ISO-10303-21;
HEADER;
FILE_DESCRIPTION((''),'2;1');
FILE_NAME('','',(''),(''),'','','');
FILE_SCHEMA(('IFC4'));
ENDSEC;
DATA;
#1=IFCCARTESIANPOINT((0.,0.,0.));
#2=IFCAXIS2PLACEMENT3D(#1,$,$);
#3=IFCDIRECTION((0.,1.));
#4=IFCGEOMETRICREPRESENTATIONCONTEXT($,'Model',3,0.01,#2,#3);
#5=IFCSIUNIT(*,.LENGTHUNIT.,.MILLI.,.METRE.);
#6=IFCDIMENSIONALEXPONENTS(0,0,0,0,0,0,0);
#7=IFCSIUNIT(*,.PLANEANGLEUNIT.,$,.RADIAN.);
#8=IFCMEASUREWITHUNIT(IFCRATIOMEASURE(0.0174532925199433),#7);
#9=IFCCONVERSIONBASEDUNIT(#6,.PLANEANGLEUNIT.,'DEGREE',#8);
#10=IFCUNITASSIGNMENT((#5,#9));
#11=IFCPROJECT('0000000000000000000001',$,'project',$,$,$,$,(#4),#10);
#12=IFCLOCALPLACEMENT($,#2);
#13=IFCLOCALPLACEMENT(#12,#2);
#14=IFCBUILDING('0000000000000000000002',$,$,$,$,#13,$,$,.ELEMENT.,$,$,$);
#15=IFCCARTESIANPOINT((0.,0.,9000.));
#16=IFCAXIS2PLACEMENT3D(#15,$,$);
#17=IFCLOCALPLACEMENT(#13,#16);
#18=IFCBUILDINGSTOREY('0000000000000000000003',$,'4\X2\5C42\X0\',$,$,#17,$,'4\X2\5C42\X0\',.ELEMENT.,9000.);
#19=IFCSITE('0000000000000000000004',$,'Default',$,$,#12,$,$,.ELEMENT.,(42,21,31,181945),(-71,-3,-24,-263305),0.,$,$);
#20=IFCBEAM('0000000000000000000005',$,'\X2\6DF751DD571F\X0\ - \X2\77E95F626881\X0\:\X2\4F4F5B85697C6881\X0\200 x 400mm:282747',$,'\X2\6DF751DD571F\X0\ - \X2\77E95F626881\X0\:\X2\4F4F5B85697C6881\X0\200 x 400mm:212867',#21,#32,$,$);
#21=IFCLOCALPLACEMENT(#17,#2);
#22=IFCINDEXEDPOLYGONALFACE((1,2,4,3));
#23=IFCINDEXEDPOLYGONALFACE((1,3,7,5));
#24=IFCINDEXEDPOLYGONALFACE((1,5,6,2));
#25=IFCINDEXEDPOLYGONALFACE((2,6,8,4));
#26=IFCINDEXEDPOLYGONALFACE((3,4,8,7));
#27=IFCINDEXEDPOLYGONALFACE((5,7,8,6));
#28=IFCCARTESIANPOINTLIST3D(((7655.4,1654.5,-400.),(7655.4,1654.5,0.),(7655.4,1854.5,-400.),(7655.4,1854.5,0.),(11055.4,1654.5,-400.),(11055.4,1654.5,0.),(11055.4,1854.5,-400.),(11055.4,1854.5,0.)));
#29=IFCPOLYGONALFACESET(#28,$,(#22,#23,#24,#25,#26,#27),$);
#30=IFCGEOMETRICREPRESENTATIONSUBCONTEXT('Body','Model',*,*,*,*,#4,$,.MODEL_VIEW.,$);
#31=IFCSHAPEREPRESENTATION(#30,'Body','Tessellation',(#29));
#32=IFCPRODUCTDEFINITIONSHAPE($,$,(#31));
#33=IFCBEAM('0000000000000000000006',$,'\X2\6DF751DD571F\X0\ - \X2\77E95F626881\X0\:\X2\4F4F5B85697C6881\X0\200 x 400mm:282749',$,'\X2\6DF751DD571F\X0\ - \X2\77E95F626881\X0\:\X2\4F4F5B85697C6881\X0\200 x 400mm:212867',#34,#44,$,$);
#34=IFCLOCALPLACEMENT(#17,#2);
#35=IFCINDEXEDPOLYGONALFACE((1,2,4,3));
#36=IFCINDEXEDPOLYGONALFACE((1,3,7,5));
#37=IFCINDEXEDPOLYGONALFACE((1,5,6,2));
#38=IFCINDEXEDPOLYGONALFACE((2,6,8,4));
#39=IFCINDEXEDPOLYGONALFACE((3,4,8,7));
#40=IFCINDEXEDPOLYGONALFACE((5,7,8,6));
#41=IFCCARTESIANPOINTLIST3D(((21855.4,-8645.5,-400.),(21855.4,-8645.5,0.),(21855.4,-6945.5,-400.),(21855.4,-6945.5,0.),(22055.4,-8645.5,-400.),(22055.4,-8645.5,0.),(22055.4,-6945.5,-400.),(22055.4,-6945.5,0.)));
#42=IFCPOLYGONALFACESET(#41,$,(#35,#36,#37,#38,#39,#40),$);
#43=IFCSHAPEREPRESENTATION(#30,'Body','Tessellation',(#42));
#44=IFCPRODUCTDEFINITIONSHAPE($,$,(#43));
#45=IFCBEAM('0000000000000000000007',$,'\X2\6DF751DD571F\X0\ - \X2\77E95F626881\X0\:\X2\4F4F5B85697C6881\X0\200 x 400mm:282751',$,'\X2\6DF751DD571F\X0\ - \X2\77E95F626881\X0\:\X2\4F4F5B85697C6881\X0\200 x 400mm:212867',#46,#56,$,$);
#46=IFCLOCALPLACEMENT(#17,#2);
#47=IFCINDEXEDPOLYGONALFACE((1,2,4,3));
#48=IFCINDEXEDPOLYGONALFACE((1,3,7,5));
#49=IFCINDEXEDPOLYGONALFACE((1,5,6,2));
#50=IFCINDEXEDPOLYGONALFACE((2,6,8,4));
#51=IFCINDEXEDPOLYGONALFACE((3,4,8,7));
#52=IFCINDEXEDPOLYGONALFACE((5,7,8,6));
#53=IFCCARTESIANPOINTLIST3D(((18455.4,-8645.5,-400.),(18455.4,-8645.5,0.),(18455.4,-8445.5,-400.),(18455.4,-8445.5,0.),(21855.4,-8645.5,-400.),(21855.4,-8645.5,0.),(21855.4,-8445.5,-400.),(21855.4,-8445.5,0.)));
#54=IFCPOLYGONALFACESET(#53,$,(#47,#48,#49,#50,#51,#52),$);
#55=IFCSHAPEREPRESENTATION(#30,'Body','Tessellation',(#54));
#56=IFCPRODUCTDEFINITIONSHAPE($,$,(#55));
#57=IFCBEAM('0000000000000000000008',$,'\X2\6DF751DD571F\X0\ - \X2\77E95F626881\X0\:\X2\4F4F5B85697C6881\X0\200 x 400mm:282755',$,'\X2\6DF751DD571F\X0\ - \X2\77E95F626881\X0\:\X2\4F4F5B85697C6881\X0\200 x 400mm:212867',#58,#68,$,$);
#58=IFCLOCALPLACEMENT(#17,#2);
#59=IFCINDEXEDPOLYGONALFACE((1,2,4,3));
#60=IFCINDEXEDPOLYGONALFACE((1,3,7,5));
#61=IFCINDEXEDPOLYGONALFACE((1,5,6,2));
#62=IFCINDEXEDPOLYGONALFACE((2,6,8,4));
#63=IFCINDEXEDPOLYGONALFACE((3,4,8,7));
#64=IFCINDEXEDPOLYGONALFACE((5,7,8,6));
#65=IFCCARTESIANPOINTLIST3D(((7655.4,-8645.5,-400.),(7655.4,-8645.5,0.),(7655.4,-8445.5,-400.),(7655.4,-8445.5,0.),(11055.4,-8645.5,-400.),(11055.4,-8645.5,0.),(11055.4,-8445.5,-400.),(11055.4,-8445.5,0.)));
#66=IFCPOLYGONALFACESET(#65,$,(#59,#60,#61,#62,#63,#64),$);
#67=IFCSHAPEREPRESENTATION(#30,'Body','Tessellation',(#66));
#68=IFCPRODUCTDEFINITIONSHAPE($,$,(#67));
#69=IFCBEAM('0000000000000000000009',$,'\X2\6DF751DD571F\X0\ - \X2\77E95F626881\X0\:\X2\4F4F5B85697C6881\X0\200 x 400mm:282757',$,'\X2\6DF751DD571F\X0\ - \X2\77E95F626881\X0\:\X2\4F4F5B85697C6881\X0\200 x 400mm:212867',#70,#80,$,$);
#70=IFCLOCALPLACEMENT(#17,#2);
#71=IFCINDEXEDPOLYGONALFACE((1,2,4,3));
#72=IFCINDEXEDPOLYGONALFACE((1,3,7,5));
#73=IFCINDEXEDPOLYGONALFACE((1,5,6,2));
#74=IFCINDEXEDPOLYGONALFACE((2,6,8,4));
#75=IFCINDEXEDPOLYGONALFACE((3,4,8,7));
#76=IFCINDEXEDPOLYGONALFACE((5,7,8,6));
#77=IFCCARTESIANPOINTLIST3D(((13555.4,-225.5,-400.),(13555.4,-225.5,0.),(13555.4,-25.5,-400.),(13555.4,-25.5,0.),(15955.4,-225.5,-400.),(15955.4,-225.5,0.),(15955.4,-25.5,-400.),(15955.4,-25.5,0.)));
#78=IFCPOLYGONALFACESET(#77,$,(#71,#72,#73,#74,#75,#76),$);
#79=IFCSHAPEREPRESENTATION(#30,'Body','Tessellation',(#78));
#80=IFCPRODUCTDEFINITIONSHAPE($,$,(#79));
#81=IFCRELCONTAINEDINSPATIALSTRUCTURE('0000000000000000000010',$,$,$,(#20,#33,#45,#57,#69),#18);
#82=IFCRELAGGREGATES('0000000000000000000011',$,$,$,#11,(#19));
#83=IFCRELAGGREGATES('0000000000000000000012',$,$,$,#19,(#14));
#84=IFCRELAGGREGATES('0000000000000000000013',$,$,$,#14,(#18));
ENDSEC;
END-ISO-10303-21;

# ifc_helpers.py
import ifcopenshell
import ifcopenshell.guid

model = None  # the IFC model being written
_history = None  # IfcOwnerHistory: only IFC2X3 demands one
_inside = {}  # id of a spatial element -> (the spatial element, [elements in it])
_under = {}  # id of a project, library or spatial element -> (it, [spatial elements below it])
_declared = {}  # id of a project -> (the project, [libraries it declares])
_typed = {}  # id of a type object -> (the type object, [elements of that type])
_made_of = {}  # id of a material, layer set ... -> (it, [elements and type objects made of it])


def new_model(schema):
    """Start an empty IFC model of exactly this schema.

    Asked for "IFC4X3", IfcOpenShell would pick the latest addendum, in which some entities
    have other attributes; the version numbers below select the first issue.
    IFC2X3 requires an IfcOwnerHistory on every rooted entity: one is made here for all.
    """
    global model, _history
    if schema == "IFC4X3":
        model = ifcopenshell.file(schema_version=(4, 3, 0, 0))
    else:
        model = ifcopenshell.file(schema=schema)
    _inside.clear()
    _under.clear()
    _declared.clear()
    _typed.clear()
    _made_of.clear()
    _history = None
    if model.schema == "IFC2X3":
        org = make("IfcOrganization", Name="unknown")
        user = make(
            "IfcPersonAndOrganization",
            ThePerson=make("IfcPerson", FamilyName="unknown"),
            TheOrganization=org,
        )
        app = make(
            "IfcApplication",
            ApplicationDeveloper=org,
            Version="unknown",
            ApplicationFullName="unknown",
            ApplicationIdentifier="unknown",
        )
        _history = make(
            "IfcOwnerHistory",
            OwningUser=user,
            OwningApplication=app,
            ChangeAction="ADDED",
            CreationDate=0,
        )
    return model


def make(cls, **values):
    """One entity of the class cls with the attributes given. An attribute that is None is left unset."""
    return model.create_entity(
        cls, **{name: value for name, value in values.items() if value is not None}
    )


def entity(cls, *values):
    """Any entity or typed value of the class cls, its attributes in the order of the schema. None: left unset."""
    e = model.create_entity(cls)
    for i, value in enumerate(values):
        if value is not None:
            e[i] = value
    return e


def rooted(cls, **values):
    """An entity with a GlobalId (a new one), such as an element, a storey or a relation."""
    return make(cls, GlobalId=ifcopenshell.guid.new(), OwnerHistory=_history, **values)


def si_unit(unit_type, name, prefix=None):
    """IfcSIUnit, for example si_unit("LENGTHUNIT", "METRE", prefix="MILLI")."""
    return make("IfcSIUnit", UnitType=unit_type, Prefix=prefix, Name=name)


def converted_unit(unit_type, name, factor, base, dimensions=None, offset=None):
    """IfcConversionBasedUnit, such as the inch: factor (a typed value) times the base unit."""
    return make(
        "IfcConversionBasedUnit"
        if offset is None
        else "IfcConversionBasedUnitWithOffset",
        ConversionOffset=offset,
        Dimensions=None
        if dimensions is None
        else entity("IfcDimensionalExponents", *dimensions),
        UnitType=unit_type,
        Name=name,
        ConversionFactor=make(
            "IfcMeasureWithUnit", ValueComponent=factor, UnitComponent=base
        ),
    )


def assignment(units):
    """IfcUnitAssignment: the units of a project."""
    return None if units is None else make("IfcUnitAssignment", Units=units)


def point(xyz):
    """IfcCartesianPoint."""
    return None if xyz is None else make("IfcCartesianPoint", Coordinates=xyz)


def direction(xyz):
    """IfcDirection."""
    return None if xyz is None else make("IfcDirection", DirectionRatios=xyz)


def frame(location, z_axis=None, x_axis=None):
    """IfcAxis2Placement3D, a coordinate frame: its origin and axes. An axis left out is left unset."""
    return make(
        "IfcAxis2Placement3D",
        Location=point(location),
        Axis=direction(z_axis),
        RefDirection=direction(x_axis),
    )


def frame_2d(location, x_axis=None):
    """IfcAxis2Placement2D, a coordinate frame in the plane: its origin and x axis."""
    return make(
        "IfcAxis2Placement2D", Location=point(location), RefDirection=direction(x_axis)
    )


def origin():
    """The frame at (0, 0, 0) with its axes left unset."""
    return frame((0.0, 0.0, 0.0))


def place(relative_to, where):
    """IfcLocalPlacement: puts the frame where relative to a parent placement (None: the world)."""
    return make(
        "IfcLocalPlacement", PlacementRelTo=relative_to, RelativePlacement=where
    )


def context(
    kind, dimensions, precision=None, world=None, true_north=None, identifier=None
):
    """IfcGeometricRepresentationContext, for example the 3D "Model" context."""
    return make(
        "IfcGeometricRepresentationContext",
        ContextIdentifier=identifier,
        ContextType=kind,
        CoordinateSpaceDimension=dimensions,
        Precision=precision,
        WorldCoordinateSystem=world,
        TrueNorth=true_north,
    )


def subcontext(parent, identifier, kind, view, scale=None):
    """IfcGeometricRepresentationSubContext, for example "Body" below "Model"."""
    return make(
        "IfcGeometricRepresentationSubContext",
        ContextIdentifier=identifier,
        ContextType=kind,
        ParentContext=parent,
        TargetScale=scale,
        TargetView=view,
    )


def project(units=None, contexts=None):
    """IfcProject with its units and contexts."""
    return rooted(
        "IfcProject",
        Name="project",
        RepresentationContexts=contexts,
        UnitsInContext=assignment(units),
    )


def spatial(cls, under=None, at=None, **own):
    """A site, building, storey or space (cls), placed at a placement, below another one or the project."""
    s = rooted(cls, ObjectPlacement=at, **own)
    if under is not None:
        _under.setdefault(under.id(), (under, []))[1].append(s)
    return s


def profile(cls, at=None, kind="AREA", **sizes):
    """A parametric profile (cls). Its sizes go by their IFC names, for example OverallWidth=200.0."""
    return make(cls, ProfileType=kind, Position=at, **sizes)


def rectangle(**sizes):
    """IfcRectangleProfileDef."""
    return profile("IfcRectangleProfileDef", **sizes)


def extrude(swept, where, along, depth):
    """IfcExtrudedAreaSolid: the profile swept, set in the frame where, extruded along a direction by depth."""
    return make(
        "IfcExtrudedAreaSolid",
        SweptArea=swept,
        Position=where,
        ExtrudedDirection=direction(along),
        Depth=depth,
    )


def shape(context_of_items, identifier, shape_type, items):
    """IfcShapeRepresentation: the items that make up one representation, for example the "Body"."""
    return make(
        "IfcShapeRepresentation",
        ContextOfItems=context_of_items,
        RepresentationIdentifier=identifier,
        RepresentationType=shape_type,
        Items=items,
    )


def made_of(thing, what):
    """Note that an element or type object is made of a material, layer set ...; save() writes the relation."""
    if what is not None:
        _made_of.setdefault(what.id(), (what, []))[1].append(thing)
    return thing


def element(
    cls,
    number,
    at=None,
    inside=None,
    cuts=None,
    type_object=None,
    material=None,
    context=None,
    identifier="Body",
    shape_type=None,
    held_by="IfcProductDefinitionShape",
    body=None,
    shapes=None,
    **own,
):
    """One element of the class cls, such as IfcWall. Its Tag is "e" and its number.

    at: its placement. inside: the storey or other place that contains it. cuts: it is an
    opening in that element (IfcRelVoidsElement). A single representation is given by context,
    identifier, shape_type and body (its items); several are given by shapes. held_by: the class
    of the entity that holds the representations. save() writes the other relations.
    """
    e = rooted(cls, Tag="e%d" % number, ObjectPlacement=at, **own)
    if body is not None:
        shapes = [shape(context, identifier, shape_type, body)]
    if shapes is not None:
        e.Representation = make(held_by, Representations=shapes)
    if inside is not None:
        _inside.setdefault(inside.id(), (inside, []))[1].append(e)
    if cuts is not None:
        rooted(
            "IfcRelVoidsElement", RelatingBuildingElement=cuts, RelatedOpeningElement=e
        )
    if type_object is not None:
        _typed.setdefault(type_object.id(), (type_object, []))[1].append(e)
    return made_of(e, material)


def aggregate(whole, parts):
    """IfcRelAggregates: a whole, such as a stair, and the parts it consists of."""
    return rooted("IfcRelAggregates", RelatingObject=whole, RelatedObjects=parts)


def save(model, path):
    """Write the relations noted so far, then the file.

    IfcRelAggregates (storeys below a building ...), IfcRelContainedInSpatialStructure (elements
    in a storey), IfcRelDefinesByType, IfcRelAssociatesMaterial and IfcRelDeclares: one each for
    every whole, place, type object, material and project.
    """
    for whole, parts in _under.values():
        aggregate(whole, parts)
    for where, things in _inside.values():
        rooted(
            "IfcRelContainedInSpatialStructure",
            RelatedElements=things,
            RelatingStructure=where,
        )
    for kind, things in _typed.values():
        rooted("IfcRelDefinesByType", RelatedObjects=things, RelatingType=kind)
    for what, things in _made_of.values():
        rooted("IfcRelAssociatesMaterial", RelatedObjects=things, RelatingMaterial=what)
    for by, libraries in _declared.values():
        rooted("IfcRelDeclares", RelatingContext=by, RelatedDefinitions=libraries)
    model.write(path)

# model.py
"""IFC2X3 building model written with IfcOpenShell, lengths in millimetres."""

from ifc_helpers import new_model, entity, si_unit, converted_unit, direction, frame, frame_2d, origin, place, context, subcontext, project, spatial, rectangle, extrude, element, save


model = new_model("IFC2X3")

# Units and contexts
model_context = context("Model", 3, precision=0.01, world=origin(), true_north=direction((0.0, 1.0)))
body_context = subcontext(model_context, "Body", "Model", "MODEL_VIEW")
ifc_project = project(units=[si_unit("LENGTHUNIT", "METRE", prefix="MILLI"), converted_unit("PLANEANGLEUNIT", "DEGREE", entity("IfcRatioMeasure", 0.0174532925199433), si_unit("PLANEANGLEUNIT", "RADIAN"), dimensions=[0, 0, 0, 0, 0, 0, 0])], contexts=[model_context])

# Site, building, storey
site_placement = place(None, origin())
site = spatial("IfcSite", under=ifc_project, at=site_placement, Name="Default", CompositionType="ELEMENT", RefLatitude=(42, 21, 31, 181945), RefLongitude=(-71, -3, -24, -263305), RefElevation=0.0)
building_placement = place(site_placement, origin())
building = spatial("IfcBuilding", under=site, at=building_placement, CompositionType="ELEMENT")
storey_placement = place(building_placement, frame((0.0, 0.0, 9000.0)))
storey = spatial("IfcBuildingStorey", under=building, at=storey_placement, Name="4层", LongName="4层", CompositionType="ELEMENT", Elevation=9000.0)

# Beams
beam_1_placement = place(storey_placement, frame((7555.4, 1754.5, 0.0)))
element("IfcBeam", 1, at=beam_1_placement, inside=storey, Name="混凝土 - 矩形梁:住宅楼梁200 x 400mm:282747", ObjectType="混凝土 - 矩形梁:住宅楼梁200 x 400mm:212867", context=body_context, shape_type="SweptSolid", body=[
    extrude(rectangle(XDim=400.0, YDim=200.0, at=frame_2d((0.0, 0.0), x_axis=(1.0, 0.0))), frame((100.0, 0.0, -200.0), z_axis=(1.0, 0.0, 0.0), x_axis=(0.0, 0.0, -1.0)), (0.0, 0.0, 1.0), 3400.0),
])
beam_2_placement = place(storey_placement, frame((21955.4, -6745.5, 0.0), z_axis=(0.0, 0.0, 1.0), x_axis=(0.0, -1.0, 0.0)))
element("IfcBeam", 2, at=beam_2_placement, inside=storey, Name="混凝土 - 矩形梁:住宅楼梁200 x 400mm:282749", ObjectType="混凝土 - 矩形梁:住宅楼梁200 x 400mm:212867", context=body_context, shape_type="SweptSolid", body=[
    extrude(rectangle(XDim=400.0, YDim=200.0, at=frame_2d((0.0, 0.0), x_axis=(1.0, 0.0))), frame((200.0, 0.0, -200.0), z_axis=(1.0, 0.0, 0.0), x_axis=(0.0, 0.0, -1.0)), (0.0, 0.0, 1.0), 1700.0),
])
beam_3_placement = place(storey_placement, frame((21955.4, -8545.5, 0.0), z_axis=(0.0, 0.0, 1.0), x_axis=(-1.0, 0.0, 0.0)))
element("IfcBeam", 3, at=beam_3_placement, inside=storey, Name="混凝土 - 矩形梁:住宅楼梁200 x 400mm:282751", ObjectType="混凝土 - 矩形梁:住宅楼梁200 x 400mm:212867", context=body_context, shape_type="SweptSolid", body=[
    extrude(rectangle(XDim=400.0, YDim=200.0, at=frame_2d((0.0, 0.0), x_axis=(1.0, 0.0))), frame((100.0, 0.0, -200.0), z_axis=(1.0, 0.0, 0.0), x_axis=(0.0, 0.0, -1.0)), (0.0, 0.0, 1.0), 3400.0),
])
beam_4_placement = place(storey_placement, frame((7555.4, -8545.5, 0.0)))
element("IfcBeam", 4, at=beam_4_placement, inside=storey, Name="混凝土 - 矩形梁:住宅楼梁200 x 400mm:282755", ObjectType="混凝土 - 矩形梁:住宅楼梁200 x 400mm:212867", context=body_context, shape_type="SweptSolid", body=[
    extrude(rectangle(XDim=400.0, YDim=200.0, at=frame_2d((0.0, 0.0), x_axis=(1.0, 0.0))), frame((100.0, 0.0, -200.0), z_axis=(1.0, 0.0, 0.0), x_axis=(0.0, 0.0, -1.0)), (0.0, 0.0, 1.0), 3400.0),
])
beam_5_placement = place(storey_placement, frame((16055.4, -125.5, 0.0), z_axis=(0.0, 0.0, 1.0), x_axis=(-1.0, 0.0, 0.0)))
element("IfcBeam", 5, at=beam_5_placement, inside=storey, Name="混凝土 - 矩形梁:住宅楼梁200 x 400mm:282757", ObjectType="混凝土 - 矩形梁:住宅楼梁200 x 400mm:212867", context=body_context, shape_type="SweptSolid", body=[
    extrude(rectangle(XDim=400.0, YDim=200.0, at=frame_2d((0.0, 0.0), x_axis=(1.0, 0.0))), frame((100.0, 0.0, -200.0), z_axis=(1.0, 0.0, 0.0), x_axis=(0.0, 0.0, -1.0)), (0.0, 0.0, 1.0), 2400.0),
])

save(model, "model.ifc")
